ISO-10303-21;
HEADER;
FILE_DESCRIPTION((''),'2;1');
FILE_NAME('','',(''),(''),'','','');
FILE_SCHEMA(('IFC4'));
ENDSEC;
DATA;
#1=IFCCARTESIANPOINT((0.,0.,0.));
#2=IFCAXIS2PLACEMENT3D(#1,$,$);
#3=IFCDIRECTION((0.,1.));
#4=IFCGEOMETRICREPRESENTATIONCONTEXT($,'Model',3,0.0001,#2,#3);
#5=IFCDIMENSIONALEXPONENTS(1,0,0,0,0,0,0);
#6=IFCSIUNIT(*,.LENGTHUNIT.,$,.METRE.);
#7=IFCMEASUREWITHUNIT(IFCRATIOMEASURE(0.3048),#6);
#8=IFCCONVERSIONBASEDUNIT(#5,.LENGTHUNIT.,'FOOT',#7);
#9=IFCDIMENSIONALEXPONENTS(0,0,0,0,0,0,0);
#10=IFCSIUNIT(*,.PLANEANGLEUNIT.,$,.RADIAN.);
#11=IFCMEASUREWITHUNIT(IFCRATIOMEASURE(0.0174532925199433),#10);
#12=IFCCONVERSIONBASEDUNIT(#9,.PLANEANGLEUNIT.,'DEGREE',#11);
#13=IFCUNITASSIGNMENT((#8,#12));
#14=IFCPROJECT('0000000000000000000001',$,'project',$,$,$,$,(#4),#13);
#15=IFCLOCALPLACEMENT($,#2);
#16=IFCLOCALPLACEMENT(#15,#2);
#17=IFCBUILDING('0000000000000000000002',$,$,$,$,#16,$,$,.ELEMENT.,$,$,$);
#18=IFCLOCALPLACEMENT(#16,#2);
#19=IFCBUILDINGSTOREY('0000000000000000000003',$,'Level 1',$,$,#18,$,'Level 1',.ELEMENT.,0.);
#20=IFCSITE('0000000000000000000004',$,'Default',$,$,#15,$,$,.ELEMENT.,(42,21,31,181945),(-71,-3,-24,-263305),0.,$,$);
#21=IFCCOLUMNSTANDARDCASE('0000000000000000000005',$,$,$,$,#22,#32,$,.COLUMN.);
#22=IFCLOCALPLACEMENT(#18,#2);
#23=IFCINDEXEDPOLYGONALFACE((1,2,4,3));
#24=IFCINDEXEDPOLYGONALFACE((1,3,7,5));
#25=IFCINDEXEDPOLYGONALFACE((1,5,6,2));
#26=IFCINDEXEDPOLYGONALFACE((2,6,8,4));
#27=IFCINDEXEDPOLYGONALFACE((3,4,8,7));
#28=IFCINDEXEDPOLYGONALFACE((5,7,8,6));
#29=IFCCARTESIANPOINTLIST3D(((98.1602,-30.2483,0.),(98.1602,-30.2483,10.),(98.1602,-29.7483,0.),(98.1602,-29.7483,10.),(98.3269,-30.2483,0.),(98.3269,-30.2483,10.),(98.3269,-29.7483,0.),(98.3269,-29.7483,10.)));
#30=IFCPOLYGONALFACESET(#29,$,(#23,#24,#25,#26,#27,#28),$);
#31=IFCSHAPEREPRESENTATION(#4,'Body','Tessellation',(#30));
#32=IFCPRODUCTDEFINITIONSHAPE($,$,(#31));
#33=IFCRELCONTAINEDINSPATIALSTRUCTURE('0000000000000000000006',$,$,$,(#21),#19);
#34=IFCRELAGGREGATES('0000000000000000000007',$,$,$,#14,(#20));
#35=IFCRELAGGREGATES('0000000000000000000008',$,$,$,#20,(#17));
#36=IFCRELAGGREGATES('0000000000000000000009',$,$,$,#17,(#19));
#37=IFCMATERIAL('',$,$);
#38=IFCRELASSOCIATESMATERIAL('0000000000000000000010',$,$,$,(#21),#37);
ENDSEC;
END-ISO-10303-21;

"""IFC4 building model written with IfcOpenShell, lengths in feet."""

from ifc_helpers import new_model, entity, si_unit, converted_unit, direction, frame, origin, place, context, project, spatial, rectangle, extrude, material, element, save


model = new_model("IFC4")

# Units and contexts
model_context = context("Model", 3, precision=0.0001, world=origin(), true_north=direction((0.0, 1.0)))
ifc_project = project(units=[converted_unit("LENGTHUNIT", "FOOT", entity("IfcRatioMeasure", 0.3048), si_unit("LENGTHUNIT", "METRE"), dimensions=[1, 0, 0, 0, 0, 0, 0]), converted_unit("PLANEANGLEUNIT", "DEGREE", entity("IfcRatioMeasure", 0.0174532925199433), si_unit("PLANEANGLEUNIT", "RADIAN"), dimensions=[0, 0, 0, 0, 0, 0, 0])], contexts=[model_context])

# Site, building, storey
site_placement = place(None, origin())
site = spatial("IfcSite", under=ifc_project, at=site_placement, Name="Default", CompositionType="ELEMENT", RefLatitude=(42, 21, 31, 181945), RefLongitude=(-71, -3, -24, -263305), RefElevation=0.0)
building_placement = place(site_placement, origin())
building = spatial("IfcBuilding", under=site, at=building_placement, CompositionType="ELEMENT")
storey_placement = place(building_placement, origin())
storey = spatial("IfcBuildingStorey", under=building, at=storey_placement, Name="Level 1", LongName="Level 1", CompositionType="ELEMENT", Elevation=0.0)

# Column
ifc_material = material(Name="")
placement = place(storey_placement, frame((98.3269, -29.9983, 0.0), z_axis=(0.0, 0.0, 1.0), x_axis=(-1.0, 0.0, 0.0)))
for number, where, z_axis, x_axis in (
    (1, (0.0833, 0.0, 0.0), (0.0, 0.0, 1.0), (1.0, 0.0, 0.0)),
):
    element("IfcColumnStandardCase", number, at=place(placement, frame(where, z_axis=z_axis, x_axis=x_axis)), inside=storey, material=ifc_material, PredefinedType="COLUMN", context=model_context, shape_type="SweptSolid", body=[
        extrude(rectangle(XDim=0.1667, YDim=0.5), origin(), (0.0, 0.0, 1.0), 10.0),
    ])

save(model, "model.ifc")
